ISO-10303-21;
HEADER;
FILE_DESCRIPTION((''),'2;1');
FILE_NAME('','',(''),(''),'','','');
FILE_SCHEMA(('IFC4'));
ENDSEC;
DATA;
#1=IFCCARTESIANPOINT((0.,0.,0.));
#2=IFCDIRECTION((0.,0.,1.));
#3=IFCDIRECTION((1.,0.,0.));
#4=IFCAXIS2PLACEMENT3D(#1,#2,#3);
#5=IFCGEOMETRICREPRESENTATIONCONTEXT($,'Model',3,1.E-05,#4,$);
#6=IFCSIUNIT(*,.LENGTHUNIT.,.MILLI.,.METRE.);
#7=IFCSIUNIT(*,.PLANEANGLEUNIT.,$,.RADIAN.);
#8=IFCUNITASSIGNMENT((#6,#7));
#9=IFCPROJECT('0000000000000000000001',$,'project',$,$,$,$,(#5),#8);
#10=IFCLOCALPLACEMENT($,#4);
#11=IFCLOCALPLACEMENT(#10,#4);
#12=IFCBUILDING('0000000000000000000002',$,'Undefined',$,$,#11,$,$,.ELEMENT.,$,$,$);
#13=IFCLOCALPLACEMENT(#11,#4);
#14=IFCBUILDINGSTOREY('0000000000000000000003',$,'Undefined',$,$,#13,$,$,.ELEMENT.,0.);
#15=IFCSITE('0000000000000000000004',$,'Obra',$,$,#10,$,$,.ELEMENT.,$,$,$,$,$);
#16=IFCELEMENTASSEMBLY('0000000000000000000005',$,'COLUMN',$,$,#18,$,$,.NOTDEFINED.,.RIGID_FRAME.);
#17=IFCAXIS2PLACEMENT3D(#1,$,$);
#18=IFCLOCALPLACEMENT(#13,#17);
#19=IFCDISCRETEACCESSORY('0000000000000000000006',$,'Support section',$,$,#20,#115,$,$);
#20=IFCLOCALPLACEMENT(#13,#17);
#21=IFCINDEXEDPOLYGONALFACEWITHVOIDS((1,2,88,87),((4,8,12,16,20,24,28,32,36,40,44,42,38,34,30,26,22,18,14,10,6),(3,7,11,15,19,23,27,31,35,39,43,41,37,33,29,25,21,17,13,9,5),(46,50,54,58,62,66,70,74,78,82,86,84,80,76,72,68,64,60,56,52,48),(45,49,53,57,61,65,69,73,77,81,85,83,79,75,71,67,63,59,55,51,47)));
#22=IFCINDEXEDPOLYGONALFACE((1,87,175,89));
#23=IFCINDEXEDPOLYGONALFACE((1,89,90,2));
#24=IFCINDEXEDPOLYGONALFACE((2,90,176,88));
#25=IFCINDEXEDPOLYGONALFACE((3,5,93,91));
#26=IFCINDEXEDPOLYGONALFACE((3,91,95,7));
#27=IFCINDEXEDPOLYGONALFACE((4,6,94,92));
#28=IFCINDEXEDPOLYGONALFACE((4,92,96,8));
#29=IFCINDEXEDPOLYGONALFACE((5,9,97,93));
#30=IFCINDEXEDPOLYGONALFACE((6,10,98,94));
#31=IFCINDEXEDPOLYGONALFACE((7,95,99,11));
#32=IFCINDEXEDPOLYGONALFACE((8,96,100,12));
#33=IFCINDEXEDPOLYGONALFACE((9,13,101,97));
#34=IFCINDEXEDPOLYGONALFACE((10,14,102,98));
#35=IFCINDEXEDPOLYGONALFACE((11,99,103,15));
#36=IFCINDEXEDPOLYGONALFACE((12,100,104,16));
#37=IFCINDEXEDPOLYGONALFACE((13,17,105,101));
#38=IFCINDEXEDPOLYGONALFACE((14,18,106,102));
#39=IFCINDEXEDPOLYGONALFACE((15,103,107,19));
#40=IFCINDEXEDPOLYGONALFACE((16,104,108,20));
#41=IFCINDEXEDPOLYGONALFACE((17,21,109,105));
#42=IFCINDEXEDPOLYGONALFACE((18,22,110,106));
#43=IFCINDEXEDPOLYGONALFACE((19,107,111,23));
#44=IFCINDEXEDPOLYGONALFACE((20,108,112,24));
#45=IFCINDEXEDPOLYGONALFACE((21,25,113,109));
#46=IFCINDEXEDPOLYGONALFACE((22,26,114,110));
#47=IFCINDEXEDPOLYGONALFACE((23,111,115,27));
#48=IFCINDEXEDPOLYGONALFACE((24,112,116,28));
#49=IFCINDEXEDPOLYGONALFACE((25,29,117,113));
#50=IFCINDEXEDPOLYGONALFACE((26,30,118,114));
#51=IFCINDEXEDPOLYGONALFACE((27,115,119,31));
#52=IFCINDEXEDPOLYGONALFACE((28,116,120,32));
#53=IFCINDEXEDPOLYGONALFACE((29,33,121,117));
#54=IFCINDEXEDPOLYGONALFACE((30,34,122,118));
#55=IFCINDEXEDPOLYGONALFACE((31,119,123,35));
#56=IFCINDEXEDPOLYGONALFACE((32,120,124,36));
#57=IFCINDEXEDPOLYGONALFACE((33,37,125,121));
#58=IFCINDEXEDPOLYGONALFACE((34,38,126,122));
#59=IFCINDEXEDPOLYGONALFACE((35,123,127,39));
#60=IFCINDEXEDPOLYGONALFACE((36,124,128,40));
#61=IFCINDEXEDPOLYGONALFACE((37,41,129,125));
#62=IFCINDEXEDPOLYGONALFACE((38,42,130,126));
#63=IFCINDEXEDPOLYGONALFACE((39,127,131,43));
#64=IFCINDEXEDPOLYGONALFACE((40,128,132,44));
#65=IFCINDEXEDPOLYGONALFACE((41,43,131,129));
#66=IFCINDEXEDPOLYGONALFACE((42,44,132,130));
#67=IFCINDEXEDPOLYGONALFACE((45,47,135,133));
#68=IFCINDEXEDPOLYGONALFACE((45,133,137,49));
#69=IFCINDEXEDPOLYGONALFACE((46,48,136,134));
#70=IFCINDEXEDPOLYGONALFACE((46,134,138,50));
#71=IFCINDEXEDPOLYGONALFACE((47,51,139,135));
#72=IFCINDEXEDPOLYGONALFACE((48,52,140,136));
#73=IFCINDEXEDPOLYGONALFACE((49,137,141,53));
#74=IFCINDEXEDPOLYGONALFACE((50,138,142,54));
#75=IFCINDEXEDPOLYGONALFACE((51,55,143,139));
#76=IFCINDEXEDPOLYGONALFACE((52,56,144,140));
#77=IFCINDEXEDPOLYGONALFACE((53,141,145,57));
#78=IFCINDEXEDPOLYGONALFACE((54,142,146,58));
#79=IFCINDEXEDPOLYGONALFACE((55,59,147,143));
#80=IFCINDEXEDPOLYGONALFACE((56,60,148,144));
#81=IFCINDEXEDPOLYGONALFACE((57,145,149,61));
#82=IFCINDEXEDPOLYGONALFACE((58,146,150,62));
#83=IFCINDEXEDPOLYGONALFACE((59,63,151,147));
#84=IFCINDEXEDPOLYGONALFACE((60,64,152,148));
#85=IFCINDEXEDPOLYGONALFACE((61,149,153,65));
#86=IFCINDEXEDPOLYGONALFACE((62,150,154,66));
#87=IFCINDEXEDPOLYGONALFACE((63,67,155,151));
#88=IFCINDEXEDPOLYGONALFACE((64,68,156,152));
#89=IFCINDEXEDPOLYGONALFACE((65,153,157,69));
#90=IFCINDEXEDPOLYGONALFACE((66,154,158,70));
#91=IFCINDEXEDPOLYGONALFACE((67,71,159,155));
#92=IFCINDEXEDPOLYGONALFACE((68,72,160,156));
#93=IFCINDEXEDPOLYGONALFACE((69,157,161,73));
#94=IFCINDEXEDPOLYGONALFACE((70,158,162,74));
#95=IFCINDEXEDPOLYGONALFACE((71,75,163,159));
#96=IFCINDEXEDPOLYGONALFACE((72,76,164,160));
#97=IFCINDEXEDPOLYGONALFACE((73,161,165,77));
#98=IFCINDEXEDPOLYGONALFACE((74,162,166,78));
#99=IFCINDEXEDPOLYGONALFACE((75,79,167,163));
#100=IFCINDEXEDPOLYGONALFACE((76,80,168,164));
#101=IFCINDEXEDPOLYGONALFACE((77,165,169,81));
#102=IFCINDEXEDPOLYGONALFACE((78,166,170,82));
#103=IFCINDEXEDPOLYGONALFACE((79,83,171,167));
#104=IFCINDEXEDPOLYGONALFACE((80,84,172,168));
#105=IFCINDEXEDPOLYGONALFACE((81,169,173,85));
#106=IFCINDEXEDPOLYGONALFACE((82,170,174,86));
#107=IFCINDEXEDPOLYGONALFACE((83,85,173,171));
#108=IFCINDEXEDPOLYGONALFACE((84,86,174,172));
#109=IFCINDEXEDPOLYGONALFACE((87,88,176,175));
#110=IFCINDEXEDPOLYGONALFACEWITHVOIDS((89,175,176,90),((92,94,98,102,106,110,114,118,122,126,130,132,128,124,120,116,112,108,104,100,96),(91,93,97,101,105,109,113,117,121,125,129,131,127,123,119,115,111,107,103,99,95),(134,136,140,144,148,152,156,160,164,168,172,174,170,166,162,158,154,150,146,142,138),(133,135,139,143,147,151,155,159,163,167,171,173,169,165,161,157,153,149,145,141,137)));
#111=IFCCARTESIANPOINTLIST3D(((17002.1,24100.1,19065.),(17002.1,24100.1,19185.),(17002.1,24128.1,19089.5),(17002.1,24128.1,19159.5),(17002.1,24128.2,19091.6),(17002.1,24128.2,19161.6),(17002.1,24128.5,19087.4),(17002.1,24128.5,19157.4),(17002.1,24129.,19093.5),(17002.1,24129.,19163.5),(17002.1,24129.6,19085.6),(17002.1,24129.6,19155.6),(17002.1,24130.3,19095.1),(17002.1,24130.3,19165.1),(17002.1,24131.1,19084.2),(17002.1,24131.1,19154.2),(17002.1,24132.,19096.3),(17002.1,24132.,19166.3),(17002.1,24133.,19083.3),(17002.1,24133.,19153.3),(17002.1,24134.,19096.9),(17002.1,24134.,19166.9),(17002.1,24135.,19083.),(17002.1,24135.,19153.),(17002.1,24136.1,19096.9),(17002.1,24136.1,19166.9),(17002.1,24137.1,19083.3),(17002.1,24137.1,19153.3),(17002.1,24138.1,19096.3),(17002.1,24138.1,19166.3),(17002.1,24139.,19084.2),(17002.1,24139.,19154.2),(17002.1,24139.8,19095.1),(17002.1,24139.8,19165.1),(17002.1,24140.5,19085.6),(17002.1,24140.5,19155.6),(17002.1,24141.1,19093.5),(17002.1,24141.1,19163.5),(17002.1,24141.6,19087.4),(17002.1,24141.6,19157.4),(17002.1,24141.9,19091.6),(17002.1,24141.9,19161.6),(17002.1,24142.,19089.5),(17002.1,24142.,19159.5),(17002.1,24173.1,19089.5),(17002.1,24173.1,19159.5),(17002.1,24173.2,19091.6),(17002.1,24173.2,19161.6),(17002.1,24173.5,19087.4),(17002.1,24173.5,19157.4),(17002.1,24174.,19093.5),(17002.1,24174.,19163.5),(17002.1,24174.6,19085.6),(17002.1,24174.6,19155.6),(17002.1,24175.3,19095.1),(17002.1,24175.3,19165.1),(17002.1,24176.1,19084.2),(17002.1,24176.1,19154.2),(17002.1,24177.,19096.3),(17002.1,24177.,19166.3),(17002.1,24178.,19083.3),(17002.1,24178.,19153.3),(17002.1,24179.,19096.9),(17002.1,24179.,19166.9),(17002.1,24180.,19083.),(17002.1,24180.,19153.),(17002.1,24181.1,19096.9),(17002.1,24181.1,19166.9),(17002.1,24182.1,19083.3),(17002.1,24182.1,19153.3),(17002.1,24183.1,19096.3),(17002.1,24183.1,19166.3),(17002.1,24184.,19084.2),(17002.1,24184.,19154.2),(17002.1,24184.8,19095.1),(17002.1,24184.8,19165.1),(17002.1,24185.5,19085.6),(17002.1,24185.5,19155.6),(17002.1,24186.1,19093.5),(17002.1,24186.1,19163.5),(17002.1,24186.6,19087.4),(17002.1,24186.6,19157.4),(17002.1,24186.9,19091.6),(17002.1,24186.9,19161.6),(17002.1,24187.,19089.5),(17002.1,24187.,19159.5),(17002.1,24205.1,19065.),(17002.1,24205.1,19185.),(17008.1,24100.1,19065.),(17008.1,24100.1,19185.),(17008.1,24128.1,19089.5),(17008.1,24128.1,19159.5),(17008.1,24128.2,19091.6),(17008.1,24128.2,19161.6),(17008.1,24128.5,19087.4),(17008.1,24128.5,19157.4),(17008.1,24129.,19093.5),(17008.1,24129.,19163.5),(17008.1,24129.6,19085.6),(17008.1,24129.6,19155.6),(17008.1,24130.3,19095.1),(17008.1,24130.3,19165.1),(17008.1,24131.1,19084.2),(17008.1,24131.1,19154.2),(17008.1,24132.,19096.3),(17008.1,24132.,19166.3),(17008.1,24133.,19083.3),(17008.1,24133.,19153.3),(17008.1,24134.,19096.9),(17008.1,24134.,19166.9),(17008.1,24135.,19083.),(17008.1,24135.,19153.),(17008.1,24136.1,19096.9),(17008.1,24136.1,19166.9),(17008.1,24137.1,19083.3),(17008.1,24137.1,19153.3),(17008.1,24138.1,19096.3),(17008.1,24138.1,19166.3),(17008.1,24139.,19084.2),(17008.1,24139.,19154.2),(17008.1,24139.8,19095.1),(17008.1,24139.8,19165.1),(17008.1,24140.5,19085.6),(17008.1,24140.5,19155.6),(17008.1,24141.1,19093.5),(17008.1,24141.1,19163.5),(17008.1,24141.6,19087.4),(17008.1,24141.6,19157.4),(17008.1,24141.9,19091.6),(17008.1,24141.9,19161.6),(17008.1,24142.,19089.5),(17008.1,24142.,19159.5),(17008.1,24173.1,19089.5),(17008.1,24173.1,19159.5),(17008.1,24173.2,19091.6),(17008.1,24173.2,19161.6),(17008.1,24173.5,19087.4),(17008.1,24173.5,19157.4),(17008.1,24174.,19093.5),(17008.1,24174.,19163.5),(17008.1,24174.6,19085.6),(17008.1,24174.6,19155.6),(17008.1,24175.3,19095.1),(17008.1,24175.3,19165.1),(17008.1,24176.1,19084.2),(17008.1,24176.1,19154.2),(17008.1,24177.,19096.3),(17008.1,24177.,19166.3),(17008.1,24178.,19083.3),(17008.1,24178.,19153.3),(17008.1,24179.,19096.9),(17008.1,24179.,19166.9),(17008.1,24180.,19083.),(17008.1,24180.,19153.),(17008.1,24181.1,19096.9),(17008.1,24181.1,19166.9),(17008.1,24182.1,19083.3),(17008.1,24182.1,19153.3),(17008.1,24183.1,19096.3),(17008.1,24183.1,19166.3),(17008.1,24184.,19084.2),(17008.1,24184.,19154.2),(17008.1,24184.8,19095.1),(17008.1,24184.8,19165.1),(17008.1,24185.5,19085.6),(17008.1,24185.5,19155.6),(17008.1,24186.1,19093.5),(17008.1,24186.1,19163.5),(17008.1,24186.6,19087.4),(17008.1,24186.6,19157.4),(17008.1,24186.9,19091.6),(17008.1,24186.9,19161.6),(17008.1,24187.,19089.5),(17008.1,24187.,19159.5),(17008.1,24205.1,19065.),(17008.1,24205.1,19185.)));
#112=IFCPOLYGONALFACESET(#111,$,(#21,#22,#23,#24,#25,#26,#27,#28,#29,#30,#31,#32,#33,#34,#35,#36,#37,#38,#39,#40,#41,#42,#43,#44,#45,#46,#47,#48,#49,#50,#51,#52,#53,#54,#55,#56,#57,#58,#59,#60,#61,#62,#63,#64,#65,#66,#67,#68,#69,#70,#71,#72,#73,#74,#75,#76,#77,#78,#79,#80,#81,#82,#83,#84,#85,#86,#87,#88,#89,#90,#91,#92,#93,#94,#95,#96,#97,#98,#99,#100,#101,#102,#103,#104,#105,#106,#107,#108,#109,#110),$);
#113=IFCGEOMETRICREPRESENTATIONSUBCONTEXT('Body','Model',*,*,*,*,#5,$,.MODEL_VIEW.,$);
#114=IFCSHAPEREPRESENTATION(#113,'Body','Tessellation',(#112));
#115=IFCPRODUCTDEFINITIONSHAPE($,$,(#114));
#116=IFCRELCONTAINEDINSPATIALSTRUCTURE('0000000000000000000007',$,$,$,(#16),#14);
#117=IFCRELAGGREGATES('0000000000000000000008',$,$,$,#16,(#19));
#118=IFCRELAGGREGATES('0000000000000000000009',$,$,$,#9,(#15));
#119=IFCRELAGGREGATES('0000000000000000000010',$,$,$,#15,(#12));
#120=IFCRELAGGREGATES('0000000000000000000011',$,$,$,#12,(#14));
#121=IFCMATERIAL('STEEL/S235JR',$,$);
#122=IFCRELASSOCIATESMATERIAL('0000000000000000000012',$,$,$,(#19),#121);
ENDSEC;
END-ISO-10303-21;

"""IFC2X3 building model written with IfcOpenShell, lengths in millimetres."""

from ifc_helpers import new_model, si_unit, frame, origin_with_axes, origin_2d_with_axis, place, context, subcontext, project, spatial, rectangle, circle, extrude, source, transform, mapped, material, element, aggregate, save


model = new_model("IFC2X3")

# Units and contexts
model_context = context("Model", 3, precision=1e-05, world=origin_with_axes())
body_context = subcontext(model_context, "Body", "Model", "MODEL_VIEW")
ifc_project = project(units=[si_unit("LENGTHUNIT", "METRE", prefix="MILLI"), si_unit("PLANEANGLEUNIT", "RADIAN")], contexts=[model_context])

# Site, building, storey
site_placement = place(None, origin_with_axes())
site = spatial("IfcSite", under=ifc_project, at=site_placement, Name="Obra", CompositionType="ELEMENT")
building_placement = place(site_placement, origin_with_axes())
building = spatial("IfcBuilding", under=site, at=building_placement, Name="Undefined", CompositionType="ELEMENT")
storey_placement = place(building_placement, origin_with_axes())
storey = spatial("IfcBuildingStorey", under=building, at=storey_placement, Name="Undefined", CompositionType="ELEMENT", Elevation=0.0)

# Element assembly
ifc_material_1 = material(Name="STEEL/S235JR")
assembly_1_placement = place(storey_placement, origin_with_axes())
assembly_1 = element("IfcElementAssembly", 1, at=assembly_1_placement, inside=storey, Name="COLUMN", AssemblyPlace="NOTDEFINED", PredefinedType="RIGID_FRAME")

# Discrete accessory, opening
shared_shape_1 = source(origin_with_axes(), body_context, "Body", "SweptSolid", [
    extrude(circle(Radius=7.0, at=origin_2d_with_axis()), frame((0.0, -8.6, 0.0), z_axis=(0.0, 1.0, 0.0), x_axis=(1.0, 0.0, 0.0)), (0.0, 0.0, 1.0), 6.2),
])
discrete_accessory_1_placement = place(assembly_1_placement, frame((17005.1, 24152.6, 19065.0), z_axis=(0.0, 0.0, 1.0), x_axis=(0.0, -1.0, 0.0)))
discrete_accessory_1 = element("IfcDiscreteAccessory", 2, at=discrete_accessory_1_placement, material=ifc_material_1, Name="Support section", context=body_context, shape_type="SweptSolid", body=[
    extrude(rectangle(XDim=6.0, YDim=105.0, at=origin_2d_with_axis()), frame((0.0, 0.0, 120.0), z_axis=(0.0, 0.0, -1.0), x_axis=(0.0, 1.0, 0.0)), (0.0, 0.0, 1.0), 120.0),
])
opening_1_placement = place(assembly_1_placement, frame((16999.6, 24110.0, 19205.0), z_axis=(0.0, 1.0, 0.0), x_axis=(0.0, 0.0, -1.0)))
element("IfcOpeningElement", 3, at=opening_1_placement, cuts=discrete_accessory_1, ObjectType="Opening", context=body_context, shape_type="MappedRepresentation", body=[
    mapped(shared_shape_1, transform((45.0, 0.0, 25.0))),
    mapped(shared_shape_1, transform((45.0, 0.0, 70.0))),
    mapped(shared_shape_1, transform((115.0, 0.0, 25.0))),
    mapped(shared_shape_1, transform((115.0, 0.0, 70.0))),
])
aggregate(assembly_1, [discrete_accessory_1])

save(model, "model.ifc")
